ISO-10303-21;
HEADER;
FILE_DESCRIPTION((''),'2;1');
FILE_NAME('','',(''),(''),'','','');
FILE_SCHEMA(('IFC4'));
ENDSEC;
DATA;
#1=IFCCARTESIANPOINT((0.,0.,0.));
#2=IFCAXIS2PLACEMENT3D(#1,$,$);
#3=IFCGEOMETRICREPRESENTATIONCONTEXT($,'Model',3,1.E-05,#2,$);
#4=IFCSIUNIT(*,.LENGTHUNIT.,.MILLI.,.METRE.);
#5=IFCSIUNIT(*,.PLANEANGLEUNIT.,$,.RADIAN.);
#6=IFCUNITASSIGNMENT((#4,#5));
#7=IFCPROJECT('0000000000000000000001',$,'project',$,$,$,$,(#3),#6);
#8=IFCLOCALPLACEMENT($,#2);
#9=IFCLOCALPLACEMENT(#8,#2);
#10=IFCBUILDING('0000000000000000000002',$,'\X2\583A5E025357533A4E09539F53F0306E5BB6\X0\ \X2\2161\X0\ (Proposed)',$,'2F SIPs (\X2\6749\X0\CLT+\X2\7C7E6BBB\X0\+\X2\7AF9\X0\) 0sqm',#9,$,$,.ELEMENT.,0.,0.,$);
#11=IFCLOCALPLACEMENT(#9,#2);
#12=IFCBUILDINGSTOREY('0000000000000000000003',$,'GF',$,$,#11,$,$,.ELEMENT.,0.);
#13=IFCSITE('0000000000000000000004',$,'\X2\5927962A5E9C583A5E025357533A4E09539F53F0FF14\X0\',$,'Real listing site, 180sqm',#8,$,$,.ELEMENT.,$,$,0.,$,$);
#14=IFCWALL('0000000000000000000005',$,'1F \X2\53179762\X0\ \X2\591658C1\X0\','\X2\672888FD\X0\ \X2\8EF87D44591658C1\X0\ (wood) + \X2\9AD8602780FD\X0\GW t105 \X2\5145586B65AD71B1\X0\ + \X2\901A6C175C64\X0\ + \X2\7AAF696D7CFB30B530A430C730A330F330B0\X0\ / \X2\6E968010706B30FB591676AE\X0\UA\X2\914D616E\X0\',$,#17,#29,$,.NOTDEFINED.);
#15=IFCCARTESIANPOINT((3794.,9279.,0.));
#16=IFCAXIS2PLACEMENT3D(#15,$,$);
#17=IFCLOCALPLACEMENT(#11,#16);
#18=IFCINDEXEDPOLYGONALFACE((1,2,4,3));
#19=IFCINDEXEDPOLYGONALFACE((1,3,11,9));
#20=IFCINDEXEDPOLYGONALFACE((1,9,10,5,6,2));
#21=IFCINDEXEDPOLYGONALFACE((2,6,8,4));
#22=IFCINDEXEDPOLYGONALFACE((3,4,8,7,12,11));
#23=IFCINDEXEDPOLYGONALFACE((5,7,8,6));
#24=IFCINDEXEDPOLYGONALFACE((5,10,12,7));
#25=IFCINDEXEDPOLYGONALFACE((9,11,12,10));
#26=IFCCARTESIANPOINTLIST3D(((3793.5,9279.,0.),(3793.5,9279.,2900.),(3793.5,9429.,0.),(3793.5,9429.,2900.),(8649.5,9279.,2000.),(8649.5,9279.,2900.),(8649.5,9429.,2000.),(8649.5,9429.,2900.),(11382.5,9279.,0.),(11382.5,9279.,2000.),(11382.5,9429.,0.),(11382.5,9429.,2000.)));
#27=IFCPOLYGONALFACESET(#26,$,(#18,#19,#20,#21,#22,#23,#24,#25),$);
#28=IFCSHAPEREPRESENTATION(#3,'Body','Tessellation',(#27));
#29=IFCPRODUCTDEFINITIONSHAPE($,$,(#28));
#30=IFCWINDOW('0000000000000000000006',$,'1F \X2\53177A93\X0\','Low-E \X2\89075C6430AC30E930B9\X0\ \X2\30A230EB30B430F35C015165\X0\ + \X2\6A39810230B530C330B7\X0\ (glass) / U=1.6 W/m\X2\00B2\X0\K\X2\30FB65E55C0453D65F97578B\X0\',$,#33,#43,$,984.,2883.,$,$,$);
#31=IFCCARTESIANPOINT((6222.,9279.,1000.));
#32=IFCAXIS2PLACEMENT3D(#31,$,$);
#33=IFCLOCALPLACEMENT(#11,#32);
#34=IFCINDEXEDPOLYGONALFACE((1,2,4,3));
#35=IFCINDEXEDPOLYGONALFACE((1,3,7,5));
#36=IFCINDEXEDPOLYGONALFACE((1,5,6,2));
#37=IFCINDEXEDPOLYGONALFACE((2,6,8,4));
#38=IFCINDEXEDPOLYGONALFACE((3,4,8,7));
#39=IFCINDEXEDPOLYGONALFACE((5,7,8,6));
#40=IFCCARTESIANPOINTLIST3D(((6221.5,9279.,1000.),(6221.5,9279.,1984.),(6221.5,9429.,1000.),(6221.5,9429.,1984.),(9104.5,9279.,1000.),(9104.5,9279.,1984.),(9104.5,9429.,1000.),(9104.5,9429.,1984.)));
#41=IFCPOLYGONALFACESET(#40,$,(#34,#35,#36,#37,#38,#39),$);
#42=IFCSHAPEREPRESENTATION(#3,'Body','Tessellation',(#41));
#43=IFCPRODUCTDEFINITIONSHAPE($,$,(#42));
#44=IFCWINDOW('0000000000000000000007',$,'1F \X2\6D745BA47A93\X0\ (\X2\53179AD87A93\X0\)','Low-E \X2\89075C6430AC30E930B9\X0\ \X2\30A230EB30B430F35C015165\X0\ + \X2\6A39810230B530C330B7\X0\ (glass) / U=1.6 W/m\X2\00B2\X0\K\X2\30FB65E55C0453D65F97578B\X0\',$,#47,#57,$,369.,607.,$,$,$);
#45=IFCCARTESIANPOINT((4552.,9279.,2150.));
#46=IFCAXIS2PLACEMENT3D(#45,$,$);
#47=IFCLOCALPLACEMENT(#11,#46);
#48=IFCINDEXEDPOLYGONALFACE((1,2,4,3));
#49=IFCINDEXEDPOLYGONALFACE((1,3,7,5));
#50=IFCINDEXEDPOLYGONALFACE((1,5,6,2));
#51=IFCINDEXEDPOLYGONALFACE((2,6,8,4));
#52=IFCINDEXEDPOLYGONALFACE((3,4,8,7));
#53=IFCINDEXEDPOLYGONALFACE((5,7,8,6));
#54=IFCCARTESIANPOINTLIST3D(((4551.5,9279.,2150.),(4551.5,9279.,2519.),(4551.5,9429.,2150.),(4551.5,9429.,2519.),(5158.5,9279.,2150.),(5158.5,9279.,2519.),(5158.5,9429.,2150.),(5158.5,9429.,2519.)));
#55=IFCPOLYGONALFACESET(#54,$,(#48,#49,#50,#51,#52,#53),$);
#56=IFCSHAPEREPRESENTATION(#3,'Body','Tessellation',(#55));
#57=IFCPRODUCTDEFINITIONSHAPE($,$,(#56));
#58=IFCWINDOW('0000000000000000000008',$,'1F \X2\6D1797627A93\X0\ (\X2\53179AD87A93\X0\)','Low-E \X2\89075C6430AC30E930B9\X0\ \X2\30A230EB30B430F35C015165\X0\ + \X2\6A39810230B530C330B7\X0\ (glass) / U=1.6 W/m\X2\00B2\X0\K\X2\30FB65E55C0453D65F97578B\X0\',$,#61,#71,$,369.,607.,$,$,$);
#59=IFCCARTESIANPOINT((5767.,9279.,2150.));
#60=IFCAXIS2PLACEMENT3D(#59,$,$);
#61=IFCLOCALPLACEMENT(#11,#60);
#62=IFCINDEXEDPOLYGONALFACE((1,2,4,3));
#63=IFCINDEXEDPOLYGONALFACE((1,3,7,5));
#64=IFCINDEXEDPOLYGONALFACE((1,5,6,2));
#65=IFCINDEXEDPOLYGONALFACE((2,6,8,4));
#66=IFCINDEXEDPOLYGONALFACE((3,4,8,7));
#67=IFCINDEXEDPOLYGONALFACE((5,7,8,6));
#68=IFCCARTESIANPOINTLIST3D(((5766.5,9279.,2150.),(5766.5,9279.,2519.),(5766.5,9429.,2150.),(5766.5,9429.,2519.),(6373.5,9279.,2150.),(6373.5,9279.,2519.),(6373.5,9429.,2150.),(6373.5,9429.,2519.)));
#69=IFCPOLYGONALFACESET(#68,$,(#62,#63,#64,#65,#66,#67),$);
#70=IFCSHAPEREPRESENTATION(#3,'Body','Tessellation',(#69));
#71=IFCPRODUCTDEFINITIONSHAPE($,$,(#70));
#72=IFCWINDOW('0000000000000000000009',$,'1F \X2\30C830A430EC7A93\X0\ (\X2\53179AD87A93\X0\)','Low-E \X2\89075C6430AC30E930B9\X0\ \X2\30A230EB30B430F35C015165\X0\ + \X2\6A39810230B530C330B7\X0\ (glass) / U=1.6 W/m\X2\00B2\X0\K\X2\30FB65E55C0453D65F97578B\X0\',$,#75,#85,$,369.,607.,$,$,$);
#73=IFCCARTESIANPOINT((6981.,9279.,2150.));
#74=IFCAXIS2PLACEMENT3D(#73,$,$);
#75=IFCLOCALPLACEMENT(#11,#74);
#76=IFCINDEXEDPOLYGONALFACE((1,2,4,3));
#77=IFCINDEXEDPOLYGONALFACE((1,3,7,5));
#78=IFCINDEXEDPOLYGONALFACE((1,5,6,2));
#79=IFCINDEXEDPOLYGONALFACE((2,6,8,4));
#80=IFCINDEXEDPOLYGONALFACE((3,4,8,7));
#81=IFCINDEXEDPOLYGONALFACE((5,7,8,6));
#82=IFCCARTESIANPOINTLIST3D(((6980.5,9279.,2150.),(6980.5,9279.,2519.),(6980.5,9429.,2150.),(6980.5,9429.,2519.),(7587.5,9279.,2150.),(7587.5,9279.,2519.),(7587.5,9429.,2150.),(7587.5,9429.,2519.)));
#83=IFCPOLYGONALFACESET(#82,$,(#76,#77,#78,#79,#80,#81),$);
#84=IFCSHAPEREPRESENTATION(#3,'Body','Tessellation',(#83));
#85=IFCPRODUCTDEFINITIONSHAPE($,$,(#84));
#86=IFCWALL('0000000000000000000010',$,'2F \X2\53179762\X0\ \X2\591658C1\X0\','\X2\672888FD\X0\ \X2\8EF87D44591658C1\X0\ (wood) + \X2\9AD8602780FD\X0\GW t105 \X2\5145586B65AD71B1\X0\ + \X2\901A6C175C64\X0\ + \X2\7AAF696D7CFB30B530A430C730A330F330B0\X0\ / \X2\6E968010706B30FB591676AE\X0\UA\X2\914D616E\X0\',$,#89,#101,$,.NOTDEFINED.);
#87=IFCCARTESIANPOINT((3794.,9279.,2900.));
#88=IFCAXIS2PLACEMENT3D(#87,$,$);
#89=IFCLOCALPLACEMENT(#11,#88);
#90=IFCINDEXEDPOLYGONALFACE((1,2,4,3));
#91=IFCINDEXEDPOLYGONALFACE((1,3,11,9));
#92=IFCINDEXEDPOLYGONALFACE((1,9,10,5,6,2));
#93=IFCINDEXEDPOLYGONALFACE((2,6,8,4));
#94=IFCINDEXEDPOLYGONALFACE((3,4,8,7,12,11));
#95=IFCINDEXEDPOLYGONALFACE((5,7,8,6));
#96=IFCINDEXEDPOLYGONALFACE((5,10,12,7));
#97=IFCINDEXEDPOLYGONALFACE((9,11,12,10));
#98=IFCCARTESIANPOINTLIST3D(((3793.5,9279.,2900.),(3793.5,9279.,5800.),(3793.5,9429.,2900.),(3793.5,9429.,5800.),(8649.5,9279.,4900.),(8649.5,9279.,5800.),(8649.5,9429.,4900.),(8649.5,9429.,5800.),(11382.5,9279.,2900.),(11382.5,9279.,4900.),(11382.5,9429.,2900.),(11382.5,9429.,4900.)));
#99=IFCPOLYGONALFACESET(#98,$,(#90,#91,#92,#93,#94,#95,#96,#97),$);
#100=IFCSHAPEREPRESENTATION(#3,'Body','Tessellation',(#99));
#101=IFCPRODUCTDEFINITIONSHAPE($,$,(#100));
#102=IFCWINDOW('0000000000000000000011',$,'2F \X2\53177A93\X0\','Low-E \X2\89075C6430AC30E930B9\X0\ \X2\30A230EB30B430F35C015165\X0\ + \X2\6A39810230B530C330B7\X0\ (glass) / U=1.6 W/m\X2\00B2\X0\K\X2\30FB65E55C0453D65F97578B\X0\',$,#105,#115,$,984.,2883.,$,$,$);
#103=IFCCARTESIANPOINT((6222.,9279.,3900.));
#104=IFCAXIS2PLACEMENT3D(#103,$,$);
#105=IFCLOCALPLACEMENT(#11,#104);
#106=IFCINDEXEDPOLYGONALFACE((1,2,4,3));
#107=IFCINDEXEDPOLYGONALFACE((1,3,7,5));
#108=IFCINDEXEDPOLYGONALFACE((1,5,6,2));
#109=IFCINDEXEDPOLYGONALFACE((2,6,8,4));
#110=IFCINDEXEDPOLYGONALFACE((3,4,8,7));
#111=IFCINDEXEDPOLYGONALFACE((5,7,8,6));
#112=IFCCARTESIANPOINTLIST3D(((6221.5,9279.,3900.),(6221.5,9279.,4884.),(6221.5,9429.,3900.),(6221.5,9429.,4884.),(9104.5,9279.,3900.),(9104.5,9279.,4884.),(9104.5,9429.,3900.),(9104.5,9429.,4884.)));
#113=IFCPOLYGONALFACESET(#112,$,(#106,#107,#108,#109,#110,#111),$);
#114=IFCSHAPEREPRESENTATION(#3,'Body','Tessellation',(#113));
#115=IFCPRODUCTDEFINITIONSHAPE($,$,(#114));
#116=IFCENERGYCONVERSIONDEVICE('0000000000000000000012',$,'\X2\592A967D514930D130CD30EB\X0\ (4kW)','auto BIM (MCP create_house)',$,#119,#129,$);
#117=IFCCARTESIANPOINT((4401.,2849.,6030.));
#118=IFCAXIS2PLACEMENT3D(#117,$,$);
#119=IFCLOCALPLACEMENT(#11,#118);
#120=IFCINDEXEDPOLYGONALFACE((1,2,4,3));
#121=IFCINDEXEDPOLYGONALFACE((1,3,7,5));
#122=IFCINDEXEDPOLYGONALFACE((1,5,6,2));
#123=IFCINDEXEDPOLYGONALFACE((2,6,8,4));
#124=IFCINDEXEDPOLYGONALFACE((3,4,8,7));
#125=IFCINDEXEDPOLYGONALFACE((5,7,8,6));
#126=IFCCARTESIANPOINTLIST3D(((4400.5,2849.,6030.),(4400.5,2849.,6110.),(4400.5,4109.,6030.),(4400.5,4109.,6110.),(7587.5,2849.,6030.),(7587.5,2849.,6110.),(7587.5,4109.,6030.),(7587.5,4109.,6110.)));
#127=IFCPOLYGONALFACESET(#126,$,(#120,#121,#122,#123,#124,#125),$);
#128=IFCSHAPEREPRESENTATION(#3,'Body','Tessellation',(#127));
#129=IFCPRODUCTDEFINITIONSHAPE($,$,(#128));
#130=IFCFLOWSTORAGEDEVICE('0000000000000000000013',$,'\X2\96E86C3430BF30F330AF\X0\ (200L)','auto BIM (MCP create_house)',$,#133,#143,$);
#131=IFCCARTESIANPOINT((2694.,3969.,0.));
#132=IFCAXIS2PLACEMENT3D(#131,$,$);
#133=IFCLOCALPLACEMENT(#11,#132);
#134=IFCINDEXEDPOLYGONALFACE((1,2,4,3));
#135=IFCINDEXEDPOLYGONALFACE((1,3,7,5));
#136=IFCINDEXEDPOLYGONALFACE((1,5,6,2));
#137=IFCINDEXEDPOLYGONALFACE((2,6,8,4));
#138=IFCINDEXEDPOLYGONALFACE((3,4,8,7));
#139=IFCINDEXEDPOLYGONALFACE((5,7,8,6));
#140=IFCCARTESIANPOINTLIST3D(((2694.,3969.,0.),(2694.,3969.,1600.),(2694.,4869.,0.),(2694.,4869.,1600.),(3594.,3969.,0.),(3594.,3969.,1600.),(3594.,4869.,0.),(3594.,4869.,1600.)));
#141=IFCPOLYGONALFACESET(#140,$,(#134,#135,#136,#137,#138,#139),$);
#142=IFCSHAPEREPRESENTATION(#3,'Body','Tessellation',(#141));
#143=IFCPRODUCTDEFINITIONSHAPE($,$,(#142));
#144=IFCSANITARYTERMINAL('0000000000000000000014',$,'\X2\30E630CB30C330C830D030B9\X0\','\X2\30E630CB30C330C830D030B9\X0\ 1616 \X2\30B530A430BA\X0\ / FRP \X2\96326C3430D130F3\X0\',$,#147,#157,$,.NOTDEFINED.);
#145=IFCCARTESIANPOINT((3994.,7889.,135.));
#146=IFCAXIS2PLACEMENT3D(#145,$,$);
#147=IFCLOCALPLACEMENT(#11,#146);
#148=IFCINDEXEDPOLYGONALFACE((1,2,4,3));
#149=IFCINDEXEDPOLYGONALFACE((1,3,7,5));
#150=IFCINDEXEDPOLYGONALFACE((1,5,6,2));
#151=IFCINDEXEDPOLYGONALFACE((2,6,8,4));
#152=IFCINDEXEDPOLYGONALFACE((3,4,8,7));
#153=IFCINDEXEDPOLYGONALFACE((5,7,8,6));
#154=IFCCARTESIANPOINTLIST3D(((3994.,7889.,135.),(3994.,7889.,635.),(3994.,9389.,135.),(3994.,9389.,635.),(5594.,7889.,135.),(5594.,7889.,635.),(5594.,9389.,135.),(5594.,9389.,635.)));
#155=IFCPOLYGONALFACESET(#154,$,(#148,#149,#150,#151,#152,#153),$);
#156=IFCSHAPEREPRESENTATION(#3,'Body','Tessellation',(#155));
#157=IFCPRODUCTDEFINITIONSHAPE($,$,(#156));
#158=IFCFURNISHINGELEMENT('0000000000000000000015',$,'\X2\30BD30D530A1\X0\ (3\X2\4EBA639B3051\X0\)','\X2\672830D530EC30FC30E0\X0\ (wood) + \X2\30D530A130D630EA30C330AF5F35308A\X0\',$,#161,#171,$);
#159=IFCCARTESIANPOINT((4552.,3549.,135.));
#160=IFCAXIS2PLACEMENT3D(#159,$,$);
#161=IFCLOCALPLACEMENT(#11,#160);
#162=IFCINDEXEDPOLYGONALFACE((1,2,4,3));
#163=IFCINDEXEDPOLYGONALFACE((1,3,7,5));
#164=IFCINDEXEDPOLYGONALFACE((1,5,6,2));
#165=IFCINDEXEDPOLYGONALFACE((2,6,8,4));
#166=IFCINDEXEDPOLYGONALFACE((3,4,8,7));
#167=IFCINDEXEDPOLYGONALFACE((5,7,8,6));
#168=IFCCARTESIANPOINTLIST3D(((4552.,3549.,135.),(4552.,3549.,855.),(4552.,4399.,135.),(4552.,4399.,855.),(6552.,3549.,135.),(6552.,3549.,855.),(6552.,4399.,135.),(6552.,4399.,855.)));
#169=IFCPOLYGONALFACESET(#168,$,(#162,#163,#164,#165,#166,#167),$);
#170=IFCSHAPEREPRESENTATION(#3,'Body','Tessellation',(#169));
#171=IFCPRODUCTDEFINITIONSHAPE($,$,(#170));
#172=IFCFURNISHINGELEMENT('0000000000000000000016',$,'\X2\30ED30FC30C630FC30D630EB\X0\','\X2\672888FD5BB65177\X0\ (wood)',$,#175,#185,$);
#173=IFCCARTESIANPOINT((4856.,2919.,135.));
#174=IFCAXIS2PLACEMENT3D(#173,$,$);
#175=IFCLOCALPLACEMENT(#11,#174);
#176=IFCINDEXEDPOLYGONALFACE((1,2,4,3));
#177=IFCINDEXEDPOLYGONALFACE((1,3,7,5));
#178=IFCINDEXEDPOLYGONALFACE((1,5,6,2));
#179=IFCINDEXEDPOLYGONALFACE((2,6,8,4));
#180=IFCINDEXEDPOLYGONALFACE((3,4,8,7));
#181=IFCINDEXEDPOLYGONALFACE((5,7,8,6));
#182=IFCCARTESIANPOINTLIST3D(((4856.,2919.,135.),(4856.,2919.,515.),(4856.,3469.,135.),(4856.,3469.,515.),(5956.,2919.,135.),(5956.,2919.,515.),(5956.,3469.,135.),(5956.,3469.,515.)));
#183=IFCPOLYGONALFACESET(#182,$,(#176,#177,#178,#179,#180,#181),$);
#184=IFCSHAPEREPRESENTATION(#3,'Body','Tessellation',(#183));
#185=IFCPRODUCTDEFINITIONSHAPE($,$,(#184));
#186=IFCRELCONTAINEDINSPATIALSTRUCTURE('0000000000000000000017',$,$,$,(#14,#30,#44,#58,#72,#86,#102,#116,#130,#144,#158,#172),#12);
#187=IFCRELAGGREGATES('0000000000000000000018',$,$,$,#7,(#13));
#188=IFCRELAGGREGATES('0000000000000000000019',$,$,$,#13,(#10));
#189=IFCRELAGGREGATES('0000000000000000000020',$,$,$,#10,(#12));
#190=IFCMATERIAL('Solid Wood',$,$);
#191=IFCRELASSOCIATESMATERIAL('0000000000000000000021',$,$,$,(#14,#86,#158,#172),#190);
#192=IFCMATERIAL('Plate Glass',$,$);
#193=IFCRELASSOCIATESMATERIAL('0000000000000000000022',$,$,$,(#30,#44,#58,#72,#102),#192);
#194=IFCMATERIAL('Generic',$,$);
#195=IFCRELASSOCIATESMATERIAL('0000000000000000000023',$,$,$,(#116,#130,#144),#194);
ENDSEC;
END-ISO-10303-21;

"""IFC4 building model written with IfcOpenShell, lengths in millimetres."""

from ifc_helpers import new_model, si_unit, frame, frame_2d, origin, place, context, project, spatial, rectangle, extrude, material, element, fill, save


model = new_model("IFC4")

# Units and contexts
model_context = context("Model", 3, precision=1e-05, world=origin())
ifc_project = project(units=[si_unit("LENGTHUNIT", "METRE", prefix="MILLI"), si_unit("PLANEANGLEUNIT", "RADIAN")], contexts=[model_context])

# Site, building, storey
site_placement = place(None, origin())
site = spatial("IfcSite", under=ifc_project, at=site_placement, Name="大阪府堺市南区三原台４", ObjectType="Real listing site, 180sqm", CompositionType="ELEMENT", RefElevation=0.0)
building_placement = place(site_placement, origin())
building = spatial("IfcBuilding", under=site, at=building_placement, Name="堺市南区三原台の家 Ⅱ (Proposed)", ObjectType="2F SIPs (杉CLT+籾殻+竹) 0sqm", CompositionType="ELEMENT", ElevationOfRefHeight=0.0, ElevationOfTerrain=0.0)
storey_placement = place(building_placement, origin())
storey = spatial("IfcBuildingStorey", under=building, at=storey_placement, Name="GF", CompositionType="ELEMENT", Elevation=0.0)

# Wall, openings, windows
ifc_material_1 = material(Name="Solid Wood")
wall_1_placement = place(storey_placement, frame((3794.0, 9279.0, 0.0)))
wall_1 = element("IfcWall", 1, at=wall_1_placement, inside=storey, material=ifc_material_1, Name="1F 北面 外壁", Description="木製 軸組外壁 (wood) + 高性能GW t105 充填断熱 + 通気層 + 窯業系サイディング / 準耐火・外皮UA配慮", PredefinedType="NOTDEFINED", context=model_context, shape_type="SweptSolid", body=[
    extrude(rectangle(XDim=7589.0, YDim=150.0, at=frame_2d((3794.0, 75.0))), frame((3794.0, 9279.0, 0.0)), (0.0, 0.0, 1.0), 2900.0),
])
opening_1_placement = place(storey_placement, frame((6222.0, 9279.0, 1000.0)))
opening_1 = element("IfcOpeningElement", 2, at=opening_1_placement, cuts=wall_1, PredefinedType="NOTDEFINED", context=model_context, shape_type="SweptSolid", body=[
    extrude(rectangle(XDim=2883.0, YDim=150.0, at=frame_2d((1441.0, 75.0))), frame((6222.0, 9279.0, 1000.0)), (0.0, 0.0, 1.0), 984.0),
])
opening_2_placement = place(storey_placement, frame((4552.0, 9279.0, 2150.0)))
opening_2 = element("IfcOpeningElement", 3, at=opening_2_placement, cuts=wall_1, PredefinedType="NOTDEFINED", context=model_context, shape_type="SweptSolid", body=[
    extrude(rectangle(XDim=607.0, YDim=150.0, at=frame_2d((303.0, 75.0))), frame((4552.0, 9279.0, 2150.0)), (0.0, 0.0, 1.0), 369.0),
])
opening_3_placement = place(storey_placement, frame((5767.0, 9279.0, 2150.0)))
opening_3 = element("IfcOpeningElement", 4, at=opening_3_placement, cuts=wall_1, PredefinedType="NOTDEFINED", context=model_context, shape_type="SweptSolid", body=[
    extrude(rectangle(XDim=607.0, YDim=150.0, at=frame_2d((303.0, 75.0))), frame((5767.0, 9279.0, 2150.0)), (0.0, 0.0, 1.0), 369.0),
])
opening_4_placement = place(storey_placement, frame((6981.0, 9279.0, 2150.0)))
opening_4 = element("IfcOpeningElement", 5, at=opening_4_placement, cuts=wall_1, PredefinedType="NOTDEFINED", context=model_context, shape_type="SweptSolid", body=[
    extrude(rectangle(XDim=607.0, YDim=150.0, at=frame_2d((303.0, 75.0))), frame((6981.0, 9279.0, 2150.0)), (0.0, 0.0, 1.0), 369.0),
])
ifc_material_2 = material(Name="Plate Glass")
window_1_placement = place(storey_placement, frame((6222.0, 9279.0, 1000.0)))
window_1 = element("IfcWindow", 6, at=window_1_placement, inside=storey, material=ifc_material_2, Name="1F 北窓", Description="Low-E 複層ガラス アルゴン封入 + 樹脂サッシ (glass) / U=1.6 W/m²K・日射取得型", OverallHeight=984.0, OverallWidth=2883.0, context=model_context, shape_type="SweptSolid", body=[
    extrude(rectangle(XDim=2883.0, YDim=150.0, at=frame_2d((1441.0, 75.0))), frame((6222.0, 9279.0, 1000.0)), (0.0, 0.0, 1.0), 984.0),
])
fill(opening_1, window_1)
window_2_placement = place(storey_placement, frame((4552.0, 9279.0, 2150.0)))
window_2 = element("IfcWindow", 7, at=window_2_placement, inside=storey, material=ifc_material_2, Name="1F 浴室窓 (北高窓)", Description="Low-E 複層ガラス アルゴン封入 + 樹脂サッシ (glass) / U=1.6 W/m²K・日射取得型", OverallHeight=369.0, OverallWidth=607.0, context=model_context, shape_type="SweptSolid", body=[
    extrude(rectangle(XDim=607.0, YDim=150.0, at=frame_2d((303.0, 75.0))), frame((4552.0, 9279.0, 2150.0)), (0.0, 0.0, 1.0), 369.0),
])
fill(opening_2, window_2)
window_3_placement = place(storey_placement, frame((5767.0, 9279.0, 2150.0)))
window_3 = element("IfcWindow", 8, at=window_3_placement, inside=storey, material=ifc_material_2, Name="1F 洗面窓 (北高窓)", Description="Low-E 複層ガラス アルゴン封入 + 樹脂サッシ (glass) / U=1.6 W/m²K・日射取得型", OverallHeight=369.0, OverallWidth=607.0, context=model_context, shape_type="SweptSolid", body=[
    extrude(rectangle(XDim=607.0, YDim=150.0, at=frame_2d((303.0, 75.0))), frame((5767.0, 9279.0, 2150.0)), (0.0, 0.0, 1.0), 369.0),
])
fill(opening_3, window_3)
window_4_placement = place(storey_placement, frame((6981.0, 9279.0, 2150.0)))
window_4 = element("IfcWindow", 9, at=window_4_placement, inside=storey, material=ifc_material_2, Name="1F トイレ窓 (北高窓)", Description="Low-E 複層ガラス アルゴン封入 + 樹脂サッシ (glass) / U=1.6 W/m²K・日射取得型", OverallHeight=369.0, OverallWidth=607.0, context=model_context, shape_type="SweptSolid", body=[
    extrude(rectangle(XDim=607.0, YDim=150.0, at=frame_2d((303.0, 75.0))), frame((6981.0, 9279.0, 2150.0)), (0.0, 0.0, 1.0), 369.0),
])
fill(opening_4, window_4)

# Wall, opening, window
wall_2_placement = place(storey_placement, frame((3794.0, 9279.0, 2900.0)))
wall_2 = element("IfcWall", 10, at=wall_2_placement, inside=storey, material=ifc_material_1, Name="2F 北面 外壁", Description="木製 軸組外壁 (wood) + 高性能GW t105 充填断熱 + 通気層 + 窯業系サイディング / 準耐火・外皮UA配慮", PredefinedType="NOTDEFINED", context=model_context, shape_type="SweptSolid", body=[
    extrude(rectangle(XDim=7589.0, YDim=150.0, at=frame_2d((3794.0, 75.0))), frame((3794.0, 9279.0, 2900.0)), (0.0, 0.0, 1.0), 2900.0),
])
opening_5_placement = place(storey_placement, frame((6222.0, 9279.0, 3900.0)))
opening_5 = element("IfcOpeningElement", 11, at=opening_5_placement, cuts=wall_2, PredefinedType="NOTDEFINED", context=model_context, shape_type="SweptSolid", body=[
    extrude(rectangle(XDim=2883.0, YDim=150.0, at=frame_2d((1441.0, 75.0))), frame((6222.0, 9279.0, 3900.0)), (0.0, 0.0, 1.0), 984.0),
])
window_5_placement = place(storey_placement, frame((6222.0, 9279.0, 3900.0)))
window_5 = element("IfcWindow", 12, at=window_5_placement, inside=storey, material=ifc_material_2, Name="2F 北窓", Description="Low-E 複層ガラス アルゴン封入 + 樹脂サッシ (glass) / U=1.6 W/m²K・日射取得型", OverallHeight=984.0, OverallWidth=2883.0, context=model_context, shape_type="SweptSolid", body=[
    extrude(rectangle(XDim=2883.0, YDim=150.0, at=frame_2d((1441.0, 75.0))), frame((6222.0, 9279.0, 3900.0)), (0.0, 0.0, 1.0), 984.0),
])
fill(opening_5, window_5)

# Energy conversion device
ifc_material_3 = material(Name="Generic")
energy_conversion_device_placement = place(storey_placement, frame((4401.0, 2849.0, 6030.0)))
element("IfcEnergyConversionDevice", 13, at=energy_conversion_device_placement, inside=storey, material=ifc_material_3, Name="太陽光パネル (4kW)", Description="auto BIM (MCP create_house)", context=model_context, shape_type="SweptSolid", body=[
    extrude(rectangle(XDim=3187.0, YDim=1260.0, at=frame_2d((1593.0, 630.0))), frame((4401.0, 2849.0, 6030.0)), (0.0, 0.0, 1.0), 80.0),
])

# Flow storage device
flow_storage_device_placement = place(storey_placement, frame((2694.0, 3969.0, 0.0)))
element("IfcFlowStorageDevice", 14, at=flow_storage_device_placement, inside=storey, material=ifc_material_3, Name="雨水タンク (200L)", Description="auto BIM (MCP create_house)", context=model_context, shape_type="SweptSolid", body=[
    extrude(rectangle(XDim=900.0, YDim=900.0, at=frame_2d((450.0, 450.0))), frame((2694.0, 3969.0, 0.0)), (0.0, 0.0, 1.0), 1600.0),
])

# Sanitary terminal
sanitary_terminal_placement = place(storey_placement, frame((3994.0, 7889.0, 135.0)))
element("IfcSanitaryTerminal", 15, at=sanitary_terminal_placement, inside=storey, material=ifc_material_3, Name="ユニットバス", Description="ユニットバス 1616 サイズ / FRP 防水パン", PredefinedType="NOTDEFINED", context=model_context, shape_type="SweptSolid", body=[
    extrude(rectangle(XDim=1600.0, YDim=1500.0, at=frame_2d((800.0, 750.0))), frame((3994.0, 7889.0, 135.0)), (0.0, 0.0, 1.0), 500.0),
])

# Furnishing elements
furnishing_1_placement = place(storey_placement, frame((4552.0, 3549.0, 135.0)))
element("IfcFurnishingElement", 16, at=furnishing_1_placement, inside=storey, material=ifc_material_1, Name="ソファ (3人掛け)", Description="木フレーム (wood) + ファブリック張り", context=model_context, shape_type="SweptSolid", body=[
    extrude(rectangle(XDim=2000.0, YDim=850.0, at=frame_2d((1000.0, 425.0))), frame((4552.0, 3549.0, 135.0)), (0.0, 0.0, 1.0), 720.0),
])
furnishing_2_placement = place(storey_placement, frame((4856.0, 2919.0, 135.0)))
element("IfcFurnishingElement", 17, at=furnishing_2_placement, inside=storey, material=ifc_material_1, Name="ローテーブル", Description="木製家具 (wood)", context=model_context, shape_type="SweptSolid", body=[
    extrude(rectangle(XDim=1100.0, YDim=550.0, at=frame_2d((550.0, 275.0))), frame((4856.0, 2919.0, 135.0)), (0.0, 0.0, 1.0), 380.0),
])

save(model, "model.ifc")
